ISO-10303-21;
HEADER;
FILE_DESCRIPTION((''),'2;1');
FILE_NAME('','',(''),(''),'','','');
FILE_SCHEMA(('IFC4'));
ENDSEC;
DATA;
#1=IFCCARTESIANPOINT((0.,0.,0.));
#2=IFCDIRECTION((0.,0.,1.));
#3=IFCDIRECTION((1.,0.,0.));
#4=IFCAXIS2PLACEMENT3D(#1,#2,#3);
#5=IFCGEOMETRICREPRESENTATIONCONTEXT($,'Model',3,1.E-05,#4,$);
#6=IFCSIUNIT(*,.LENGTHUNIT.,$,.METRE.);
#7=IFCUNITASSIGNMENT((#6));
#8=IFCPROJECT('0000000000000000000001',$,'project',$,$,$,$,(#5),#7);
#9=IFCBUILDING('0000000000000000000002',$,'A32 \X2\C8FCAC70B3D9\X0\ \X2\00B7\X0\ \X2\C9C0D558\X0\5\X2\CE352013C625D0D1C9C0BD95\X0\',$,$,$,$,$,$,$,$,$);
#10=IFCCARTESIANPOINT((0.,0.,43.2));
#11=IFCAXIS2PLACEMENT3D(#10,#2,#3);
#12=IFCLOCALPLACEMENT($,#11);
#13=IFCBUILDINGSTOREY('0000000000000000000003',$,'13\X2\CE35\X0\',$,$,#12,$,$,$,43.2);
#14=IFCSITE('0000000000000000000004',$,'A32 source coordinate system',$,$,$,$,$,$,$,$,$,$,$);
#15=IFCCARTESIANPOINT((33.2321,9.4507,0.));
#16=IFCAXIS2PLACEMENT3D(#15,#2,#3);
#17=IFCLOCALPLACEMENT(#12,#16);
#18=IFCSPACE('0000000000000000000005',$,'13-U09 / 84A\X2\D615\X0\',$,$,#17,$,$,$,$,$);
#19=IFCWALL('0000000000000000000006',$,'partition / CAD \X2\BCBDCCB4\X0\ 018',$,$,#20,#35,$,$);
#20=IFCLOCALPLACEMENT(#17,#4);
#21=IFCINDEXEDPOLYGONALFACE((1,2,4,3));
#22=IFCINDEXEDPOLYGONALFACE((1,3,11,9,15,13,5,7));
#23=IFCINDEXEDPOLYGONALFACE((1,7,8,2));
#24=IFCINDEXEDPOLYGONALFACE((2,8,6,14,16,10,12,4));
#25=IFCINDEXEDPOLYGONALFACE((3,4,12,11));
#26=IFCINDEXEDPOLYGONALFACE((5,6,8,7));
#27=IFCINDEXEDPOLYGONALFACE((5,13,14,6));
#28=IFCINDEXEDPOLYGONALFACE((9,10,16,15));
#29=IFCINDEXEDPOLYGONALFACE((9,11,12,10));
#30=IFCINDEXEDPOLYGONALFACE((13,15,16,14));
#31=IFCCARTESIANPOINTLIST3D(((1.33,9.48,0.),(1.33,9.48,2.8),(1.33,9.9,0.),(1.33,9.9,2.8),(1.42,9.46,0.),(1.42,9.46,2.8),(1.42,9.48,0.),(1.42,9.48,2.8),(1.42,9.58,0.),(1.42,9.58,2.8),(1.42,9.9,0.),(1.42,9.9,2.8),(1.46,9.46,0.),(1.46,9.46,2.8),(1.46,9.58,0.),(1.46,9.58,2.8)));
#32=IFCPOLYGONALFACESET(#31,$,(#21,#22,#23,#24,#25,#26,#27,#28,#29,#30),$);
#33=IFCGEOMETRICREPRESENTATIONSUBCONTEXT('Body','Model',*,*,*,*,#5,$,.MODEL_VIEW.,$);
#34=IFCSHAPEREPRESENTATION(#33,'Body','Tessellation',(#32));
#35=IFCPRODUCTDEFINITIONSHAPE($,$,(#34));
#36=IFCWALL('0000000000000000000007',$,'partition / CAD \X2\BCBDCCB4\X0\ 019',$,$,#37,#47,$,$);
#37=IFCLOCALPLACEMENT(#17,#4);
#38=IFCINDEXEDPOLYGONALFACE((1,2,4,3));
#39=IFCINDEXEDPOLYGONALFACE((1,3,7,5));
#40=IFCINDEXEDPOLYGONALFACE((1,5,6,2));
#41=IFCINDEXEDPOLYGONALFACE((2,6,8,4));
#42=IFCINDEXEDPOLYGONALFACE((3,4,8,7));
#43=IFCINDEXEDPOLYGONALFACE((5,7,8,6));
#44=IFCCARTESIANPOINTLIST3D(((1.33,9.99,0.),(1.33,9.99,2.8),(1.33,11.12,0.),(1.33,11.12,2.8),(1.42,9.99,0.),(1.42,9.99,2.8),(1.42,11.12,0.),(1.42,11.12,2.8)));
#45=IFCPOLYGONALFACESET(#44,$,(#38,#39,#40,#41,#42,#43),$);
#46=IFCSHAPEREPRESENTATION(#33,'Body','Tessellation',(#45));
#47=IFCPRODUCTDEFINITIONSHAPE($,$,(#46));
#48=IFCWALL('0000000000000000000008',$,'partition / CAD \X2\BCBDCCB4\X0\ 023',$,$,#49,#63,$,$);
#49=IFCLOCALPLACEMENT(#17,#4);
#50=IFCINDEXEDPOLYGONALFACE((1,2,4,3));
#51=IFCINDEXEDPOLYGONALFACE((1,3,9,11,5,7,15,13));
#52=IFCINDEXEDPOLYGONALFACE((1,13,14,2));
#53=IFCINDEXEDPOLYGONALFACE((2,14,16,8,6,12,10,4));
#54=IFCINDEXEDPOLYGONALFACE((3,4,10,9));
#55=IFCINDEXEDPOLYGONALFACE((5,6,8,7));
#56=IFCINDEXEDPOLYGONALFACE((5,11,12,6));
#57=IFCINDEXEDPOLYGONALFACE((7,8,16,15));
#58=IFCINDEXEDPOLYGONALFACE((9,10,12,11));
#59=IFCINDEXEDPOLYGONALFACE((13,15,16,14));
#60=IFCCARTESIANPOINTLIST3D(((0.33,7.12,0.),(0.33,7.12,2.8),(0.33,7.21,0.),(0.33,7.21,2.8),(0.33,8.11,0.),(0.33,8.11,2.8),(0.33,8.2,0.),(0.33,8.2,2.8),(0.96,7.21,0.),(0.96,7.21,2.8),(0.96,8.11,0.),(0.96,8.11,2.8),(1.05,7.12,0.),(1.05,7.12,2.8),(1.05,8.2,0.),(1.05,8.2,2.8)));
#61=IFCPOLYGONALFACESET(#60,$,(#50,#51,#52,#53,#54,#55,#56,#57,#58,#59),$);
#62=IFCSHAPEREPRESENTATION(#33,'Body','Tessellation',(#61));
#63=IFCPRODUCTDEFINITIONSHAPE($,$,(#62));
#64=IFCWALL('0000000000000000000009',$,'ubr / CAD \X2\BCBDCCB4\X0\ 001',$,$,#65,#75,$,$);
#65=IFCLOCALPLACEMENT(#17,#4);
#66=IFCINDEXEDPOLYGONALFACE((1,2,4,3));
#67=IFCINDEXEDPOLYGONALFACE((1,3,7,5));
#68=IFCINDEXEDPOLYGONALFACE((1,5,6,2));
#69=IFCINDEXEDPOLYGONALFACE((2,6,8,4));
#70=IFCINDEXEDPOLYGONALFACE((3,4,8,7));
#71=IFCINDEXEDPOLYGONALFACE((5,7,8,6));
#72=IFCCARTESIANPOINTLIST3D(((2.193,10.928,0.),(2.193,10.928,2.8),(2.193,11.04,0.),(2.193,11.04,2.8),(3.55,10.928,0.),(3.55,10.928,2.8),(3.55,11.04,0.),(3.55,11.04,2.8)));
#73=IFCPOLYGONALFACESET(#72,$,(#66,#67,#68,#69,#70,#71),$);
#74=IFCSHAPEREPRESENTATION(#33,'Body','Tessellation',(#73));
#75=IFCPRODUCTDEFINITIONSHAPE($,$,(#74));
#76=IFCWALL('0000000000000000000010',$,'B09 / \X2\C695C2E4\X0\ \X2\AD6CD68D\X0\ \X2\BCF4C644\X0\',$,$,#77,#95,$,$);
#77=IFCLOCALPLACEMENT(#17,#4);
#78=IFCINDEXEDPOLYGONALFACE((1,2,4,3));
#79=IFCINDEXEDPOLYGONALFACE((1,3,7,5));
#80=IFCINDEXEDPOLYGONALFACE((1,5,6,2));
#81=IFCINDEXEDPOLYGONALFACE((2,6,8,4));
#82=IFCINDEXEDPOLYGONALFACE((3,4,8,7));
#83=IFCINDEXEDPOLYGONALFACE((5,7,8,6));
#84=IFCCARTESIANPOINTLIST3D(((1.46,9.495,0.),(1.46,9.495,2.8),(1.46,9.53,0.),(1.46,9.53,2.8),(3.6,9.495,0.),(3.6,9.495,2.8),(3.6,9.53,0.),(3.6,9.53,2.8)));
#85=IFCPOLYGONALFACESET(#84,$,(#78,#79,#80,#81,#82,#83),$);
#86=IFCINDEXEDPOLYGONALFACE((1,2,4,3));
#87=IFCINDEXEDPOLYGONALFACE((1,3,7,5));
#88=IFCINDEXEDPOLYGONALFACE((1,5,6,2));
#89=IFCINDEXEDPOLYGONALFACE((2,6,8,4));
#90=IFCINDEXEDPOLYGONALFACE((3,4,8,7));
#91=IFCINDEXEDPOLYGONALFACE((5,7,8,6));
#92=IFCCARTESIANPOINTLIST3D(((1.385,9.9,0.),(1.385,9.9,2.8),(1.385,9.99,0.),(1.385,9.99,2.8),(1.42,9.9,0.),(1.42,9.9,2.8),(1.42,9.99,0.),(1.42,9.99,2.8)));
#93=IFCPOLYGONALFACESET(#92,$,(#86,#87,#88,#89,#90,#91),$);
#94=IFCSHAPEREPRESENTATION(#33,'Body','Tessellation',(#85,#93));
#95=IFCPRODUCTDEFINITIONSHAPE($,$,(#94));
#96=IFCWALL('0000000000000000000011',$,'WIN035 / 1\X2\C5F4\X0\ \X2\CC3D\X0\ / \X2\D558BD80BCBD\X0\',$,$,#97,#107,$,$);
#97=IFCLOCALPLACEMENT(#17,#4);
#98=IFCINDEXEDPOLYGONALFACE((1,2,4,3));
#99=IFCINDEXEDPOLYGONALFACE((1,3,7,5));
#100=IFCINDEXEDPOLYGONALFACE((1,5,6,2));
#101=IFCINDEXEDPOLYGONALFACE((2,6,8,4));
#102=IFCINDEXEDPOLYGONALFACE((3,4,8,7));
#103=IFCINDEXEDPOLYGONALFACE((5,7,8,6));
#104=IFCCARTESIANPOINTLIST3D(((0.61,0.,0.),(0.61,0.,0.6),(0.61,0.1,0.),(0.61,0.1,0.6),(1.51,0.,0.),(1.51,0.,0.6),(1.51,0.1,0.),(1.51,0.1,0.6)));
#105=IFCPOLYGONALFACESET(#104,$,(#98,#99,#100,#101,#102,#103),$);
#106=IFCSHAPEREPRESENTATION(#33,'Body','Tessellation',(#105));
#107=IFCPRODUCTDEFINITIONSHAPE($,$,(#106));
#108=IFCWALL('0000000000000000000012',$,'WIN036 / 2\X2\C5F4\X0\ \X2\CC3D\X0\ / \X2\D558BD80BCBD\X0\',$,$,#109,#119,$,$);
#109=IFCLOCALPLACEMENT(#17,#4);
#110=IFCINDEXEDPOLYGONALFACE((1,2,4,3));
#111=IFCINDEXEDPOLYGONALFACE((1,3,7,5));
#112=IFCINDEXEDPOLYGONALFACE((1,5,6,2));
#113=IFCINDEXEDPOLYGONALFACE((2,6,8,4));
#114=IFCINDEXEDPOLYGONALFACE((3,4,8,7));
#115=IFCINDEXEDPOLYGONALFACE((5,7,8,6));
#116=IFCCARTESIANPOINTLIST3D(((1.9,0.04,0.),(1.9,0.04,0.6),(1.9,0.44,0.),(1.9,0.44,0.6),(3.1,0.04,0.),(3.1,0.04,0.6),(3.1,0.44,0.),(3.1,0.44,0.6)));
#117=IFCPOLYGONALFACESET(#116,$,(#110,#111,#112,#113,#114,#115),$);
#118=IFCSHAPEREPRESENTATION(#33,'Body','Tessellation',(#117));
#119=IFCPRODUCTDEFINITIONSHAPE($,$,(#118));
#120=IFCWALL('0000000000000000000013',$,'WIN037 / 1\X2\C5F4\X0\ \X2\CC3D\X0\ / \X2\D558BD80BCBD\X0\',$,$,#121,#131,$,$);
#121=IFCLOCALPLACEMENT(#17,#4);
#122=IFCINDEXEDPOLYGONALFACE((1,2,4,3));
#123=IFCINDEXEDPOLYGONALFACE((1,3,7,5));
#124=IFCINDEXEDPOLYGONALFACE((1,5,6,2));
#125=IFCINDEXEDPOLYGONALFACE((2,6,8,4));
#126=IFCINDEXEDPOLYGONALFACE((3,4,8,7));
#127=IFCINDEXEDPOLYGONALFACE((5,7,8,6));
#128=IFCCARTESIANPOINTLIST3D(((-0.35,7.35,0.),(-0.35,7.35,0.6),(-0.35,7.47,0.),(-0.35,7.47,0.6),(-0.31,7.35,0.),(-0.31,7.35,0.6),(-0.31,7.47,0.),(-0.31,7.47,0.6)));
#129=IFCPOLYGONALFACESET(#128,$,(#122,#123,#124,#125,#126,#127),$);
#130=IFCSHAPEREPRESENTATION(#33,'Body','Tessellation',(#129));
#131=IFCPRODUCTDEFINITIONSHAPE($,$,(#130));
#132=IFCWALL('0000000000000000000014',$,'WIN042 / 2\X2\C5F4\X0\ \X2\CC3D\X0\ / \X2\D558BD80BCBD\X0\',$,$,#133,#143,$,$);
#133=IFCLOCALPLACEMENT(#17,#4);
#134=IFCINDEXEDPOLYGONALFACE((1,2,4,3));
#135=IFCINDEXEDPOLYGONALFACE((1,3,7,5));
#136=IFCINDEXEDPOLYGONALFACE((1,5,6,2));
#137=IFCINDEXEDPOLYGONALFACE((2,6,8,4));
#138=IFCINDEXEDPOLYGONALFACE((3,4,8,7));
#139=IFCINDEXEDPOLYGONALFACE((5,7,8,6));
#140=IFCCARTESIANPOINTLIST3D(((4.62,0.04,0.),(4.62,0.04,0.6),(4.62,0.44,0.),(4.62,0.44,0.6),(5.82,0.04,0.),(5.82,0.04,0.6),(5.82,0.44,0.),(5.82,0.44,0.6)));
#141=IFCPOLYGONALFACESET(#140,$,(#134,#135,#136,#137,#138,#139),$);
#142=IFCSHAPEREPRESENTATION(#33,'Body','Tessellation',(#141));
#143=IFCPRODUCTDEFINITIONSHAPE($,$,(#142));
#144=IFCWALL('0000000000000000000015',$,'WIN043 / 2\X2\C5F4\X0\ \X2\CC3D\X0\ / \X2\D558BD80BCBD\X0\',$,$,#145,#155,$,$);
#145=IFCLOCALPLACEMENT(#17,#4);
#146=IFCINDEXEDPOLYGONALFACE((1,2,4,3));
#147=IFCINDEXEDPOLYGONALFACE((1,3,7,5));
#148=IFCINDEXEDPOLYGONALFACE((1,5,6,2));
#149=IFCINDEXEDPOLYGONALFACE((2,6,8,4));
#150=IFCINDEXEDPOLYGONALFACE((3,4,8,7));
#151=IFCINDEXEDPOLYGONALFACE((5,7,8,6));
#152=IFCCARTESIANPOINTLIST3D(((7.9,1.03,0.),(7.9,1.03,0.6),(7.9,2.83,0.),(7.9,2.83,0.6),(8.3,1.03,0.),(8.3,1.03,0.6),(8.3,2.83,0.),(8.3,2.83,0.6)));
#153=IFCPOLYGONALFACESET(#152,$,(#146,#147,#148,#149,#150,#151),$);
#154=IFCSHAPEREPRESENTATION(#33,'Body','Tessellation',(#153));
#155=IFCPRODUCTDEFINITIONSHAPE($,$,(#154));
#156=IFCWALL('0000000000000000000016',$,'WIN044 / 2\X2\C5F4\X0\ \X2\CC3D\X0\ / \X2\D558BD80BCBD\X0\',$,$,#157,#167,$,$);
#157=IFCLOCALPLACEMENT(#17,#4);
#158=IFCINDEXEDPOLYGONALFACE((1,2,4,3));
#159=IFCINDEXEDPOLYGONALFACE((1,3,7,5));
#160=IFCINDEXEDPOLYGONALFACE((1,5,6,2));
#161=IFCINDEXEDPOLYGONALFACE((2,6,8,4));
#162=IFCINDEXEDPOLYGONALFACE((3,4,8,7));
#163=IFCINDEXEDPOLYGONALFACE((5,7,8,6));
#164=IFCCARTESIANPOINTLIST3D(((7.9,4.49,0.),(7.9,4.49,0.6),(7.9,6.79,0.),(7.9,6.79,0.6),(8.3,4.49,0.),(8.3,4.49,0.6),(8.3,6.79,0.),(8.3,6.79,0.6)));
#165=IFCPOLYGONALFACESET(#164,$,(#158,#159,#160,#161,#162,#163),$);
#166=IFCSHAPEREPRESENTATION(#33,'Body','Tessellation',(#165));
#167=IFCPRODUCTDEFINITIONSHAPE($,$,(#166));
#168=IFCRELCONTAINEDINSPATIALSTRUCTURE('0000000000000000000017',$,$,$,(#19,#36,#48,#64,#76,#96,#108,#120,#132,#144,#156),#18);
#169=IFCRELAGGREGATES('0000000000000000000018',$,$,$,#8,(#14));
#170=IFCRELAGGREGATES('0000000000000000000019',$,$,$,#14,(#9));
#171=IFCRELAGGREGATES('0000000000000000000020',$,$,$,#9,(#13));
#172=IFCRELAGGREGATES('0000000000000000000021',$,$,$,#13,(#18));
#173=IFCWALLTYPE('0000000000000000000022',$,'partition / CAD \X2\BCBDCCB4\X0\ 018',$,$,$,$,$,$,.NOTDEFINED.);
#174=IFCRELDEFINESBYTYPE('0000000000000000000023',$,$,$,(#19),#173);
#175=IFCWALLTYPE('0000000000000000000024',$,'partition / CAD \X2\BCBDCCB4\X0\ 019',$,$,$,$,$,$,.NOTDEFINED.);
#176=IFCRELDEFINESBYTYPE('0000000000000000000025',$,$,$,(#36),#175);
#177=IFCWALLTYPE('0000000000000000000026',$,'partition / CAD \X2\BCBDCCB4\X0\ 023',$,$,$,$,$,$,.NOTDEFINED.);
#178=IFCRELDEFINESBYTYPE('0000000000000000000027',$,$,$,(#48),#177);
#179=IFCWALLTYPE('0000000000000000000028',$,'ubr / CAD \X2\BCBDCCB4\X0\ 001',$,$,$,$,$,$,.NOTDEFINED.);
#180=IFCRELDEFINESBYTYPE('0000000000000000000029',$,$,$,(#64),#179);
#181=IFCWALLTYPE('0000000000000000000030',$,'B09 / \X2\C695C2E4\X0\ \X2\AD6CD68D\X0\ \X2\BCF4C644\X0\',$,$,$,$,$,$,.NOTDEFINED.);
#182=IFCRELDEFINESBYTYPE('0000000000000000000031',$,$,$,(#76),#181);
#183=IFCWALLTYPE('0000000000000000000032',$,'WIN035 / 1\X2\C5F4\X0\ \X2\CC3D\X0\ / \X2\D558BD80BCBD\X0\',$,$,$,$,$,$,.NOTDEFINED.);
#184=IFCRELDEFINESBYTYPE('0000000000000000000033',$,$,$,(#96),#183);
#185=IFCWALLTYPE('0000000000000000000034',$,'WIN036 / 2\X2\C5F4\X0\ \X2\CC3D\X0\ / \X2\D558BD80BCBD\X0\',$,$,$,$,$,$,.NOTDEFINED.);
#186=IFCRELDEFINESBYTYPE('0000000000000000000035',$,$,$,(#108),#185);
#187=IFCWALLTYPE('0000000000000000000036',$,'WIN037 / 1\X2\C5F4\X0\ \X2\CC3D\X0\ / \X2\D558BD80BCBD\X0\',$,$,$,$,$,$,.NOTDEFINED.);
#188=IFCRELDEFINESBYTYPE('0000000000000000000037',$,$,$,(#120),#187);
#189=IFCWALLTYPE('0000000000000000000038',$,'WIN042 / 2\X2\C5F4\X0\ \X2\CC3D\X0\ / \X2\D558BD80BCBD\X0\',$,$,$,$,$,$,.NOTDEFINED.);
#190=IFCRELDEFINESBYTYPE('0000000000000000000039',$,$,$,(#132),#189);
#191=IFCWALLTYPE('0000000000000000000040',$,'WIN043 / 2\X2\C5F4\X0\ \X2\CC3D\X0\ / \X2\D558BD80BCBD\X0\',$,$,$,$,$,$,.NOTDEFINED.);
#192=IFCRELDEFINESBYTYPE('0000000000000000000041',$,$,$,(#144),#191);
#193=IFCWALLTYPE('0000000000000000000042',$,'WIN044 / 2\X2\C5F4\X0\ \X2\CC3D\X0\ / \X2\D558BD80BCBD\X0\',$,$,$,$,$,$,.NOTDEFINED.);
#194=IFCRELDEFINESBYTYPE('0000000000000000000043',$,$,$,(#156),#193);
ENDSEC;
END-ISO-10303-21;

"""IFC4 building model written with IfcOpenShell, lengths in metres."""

from ifc_helpers import new_model, si_unit, frame, origin, origin_with_axes, place, context, subcontext, project, spatial, polyline, outline, extrude, source, transform, mapped, type_object, type_shapes, element, save


model = new_model("IFC4")

# Units and contexts
model_context = context("Model", 3, precision=1e-05, world=origin_with_axes())
body_context = subcontext(model_context, "Body", "Model", "MODEL_VIEW")
ifc_project = project(units=[si_unit("LENGTHUNIT", "METRE")], contexts=[model_context])

# Site, building, storey, space
site = spatial("IfcSite", under=ifc_project, Name="A32 source coordinate system")
building = spatial("IfcBuilding", under=site, Name="A32 주거동 · 지하5층–옥탑지붕")
storey_placement = place(None, frame((0.0, 0.0, 43.2), z_axis=(0.0, 0.0, 1.0), x_axis=(1.0, 0.0, 0.0)))
storey = spatial("IfcBuildingStorey", under=building, at=storey_placement, Name="13층", Elevation=43.2)
space_1_placement = place(storey_placement, frame((33.2321, 9.4507, 0.0), z_axis=(0.0, 0.0, 1.0), x_axis=(1.0, 0.0, 0.0)))
space_1 = spatial("IfcSpace", under=storey, at=space_1_placement, Name="13-U09 / 84A형")

# Walls
wall_type_1 = type_object("IfcWallType", Name="partition / CAD 벽체 018", PredefinedType="NOTDEFINED")
shared_shape_1 = source(origin(), body_context, "Body", "SweptSolid", [
    extrude(outline(polyline([(1.42, 9.58), (1.46, 9.58), (1.46, 9.46), (1.42, 9.46), (1.42, 9.48), (1.33, 9.48), (1.33, 9.9), (1.42, 9.9), (1.42, 9.58)])), origin(), (0.0, 0.0, 1.0), 2.8),
])
type_shapes(wall_type_1, [shared_shape_1])
wall_1_placement = place(space_1_placement, origin_with_axes())
element("IfcWall", 1, at=wall_1_placement, inside=space_1, type_object=wall_type_1, Name="partition / CAD 벽체 018", context=body_context, shape_type="MappedRepresentation", body=[
    mapped(shared_shape_1, transform((0.0, 0.0, 0.0), scale=1.0)),
])
wall_type_2 = type_object("IfcWallType", Name="partition / CAD 벽체 019", PredefinedType="NOTDEFINED")
shared_shape_2 = source(origin(), body_context, "Body", "SweptSolid", [
    extrude(outline(polyline([(1.33, 11.12), (1.42, 11.12), (1.42, 9.99), (1.33, 9.99), (1.33, 11.12)])), origin(), (0.0, 0.0, 1.0), 2.8),
])
type_shapes(wall_type_2, [shared_shape_2])
wall_2_placement = place(space_1_placement, origin_with_axes())
element("IfcWall", 2, at=wall_2_placement, inside=space_1, type_object=wall_type_2, Name="partition / CAD 벽체 019", context=body_context, shape_type="MappedRepresentation", body=[
    mapped(shared_shape_2, transform((0.0, 0.0, 0.0), scale=1.0)),
])
wall_type_3 = type_object("IfcWallType", Name="partition / CAD 벽체 023", PredefinedType="NOTDEFINED")
shared_shape_3 = source(origin(), body_context, "Body", "SweptSolid", [
    extrude(outline(polyline([(0.96, 8.11), (0.33, 8.11), (0.33, 8.2), (1.05, 8.2), (1.05, 7.12), (0.33, 7.12), (0.33, 7.21), (0.96, 7.21), (0.96, 8.11)])), origin(), (0.0, 0.0, 1.0), 2.8),
])
type_shapes(wall_type_3, [shared_shape_3])
wall_3_placement = place(space_1_placement, origin_with_axes())
element("IfcWall", 3, at=wall_3_placement, inside=space_1, type_object=wall_type_3, Name="partition / CAD 벽체 023", context=body_context, shape_type="MappedRepresentation", body=[
    mapped(shared_shape_3, transform((0.0, 0.0, 0.0), scale=1.0)),
])
wall_type_4 = type_object("IfcWallType", Name="ubr / CAD 벽체 001", PredefinedType="NOTDEFINED")
shared_shape_4 = source(origin(), body_context, "Body", "SweptSolid", [
    extrude(outline(polyline([(3.55, 11.04), (3.55, 10.928), (2.193, 10.928), (2.193, 11.04), (3.55, 11.04)])), origin(), (0.0, 0.0, 1.0), 2.8),
])
type_shapes(wall_type_4, [shared_shape_4])
wall_4_placement = place(space_1_placement, origin_with_axes())
element("IfcWall", 4, at=wall_4_placement, inside=space_1, type_object=wall_type_4, Name="ubr / CAD 벽체 001", context=body_context, shape_type="MappedRepresentation", body=[
    mapped(shared_shape_4, transform((0.0, 0.0, 0.0), scale=1.0)),
])
wall_type_5 = type_object("IfcWallType", Name="B09 / 욕실 구획 보완", PredefinedType="NOTDEFINED")
shared_shape_5 = source(origin(), body_context, "Body", "SweptSolid", [
    extrude(outline(polyline([(3.6, 9.53), (3.6, 9.495), (1.46, 9.495), (1.46, 9.53), (3.6, 9.53)])), origin(), (0.0, 0.0, 1.0), 2.8),
    extrude(outline(polyline([(1.42, 9.9), (1.385, 9.9), (1.385, 9.99), (1.42, 9.99), (1.42, 9.9)])), origin(), (0.0, 0.0, 1.0), 2.8),
])
type_shapes(wall_type_5, [shared_shape_5])
wall_5_placement = place(space_1_placement, origin_with_axes())
element("IfcWall", 5, at=wall_5_placement, inside=space_1, type_object=wall_type_5, Name="B09 / 욕실 구획 보완", context=body_context, shape_type="MappedRepresentation", body=[
    mapped(shared_shape_5, transform((0.0, 0.0, 0.0), scale=1.0)),
])
wall_type_6 = type_object("IfcWallType", Name="WIN035 / 1열 창 / 하부벽", PredefinedType="NOTDEFINED")
shared_shape_6 = source(origin(), body_context, "Body", "SweptSolid", [
    extrude(outline(polyline([(0.61, 0.1), (1.51, 0.1), (1.51, 0.0), (0.61, 0.0), (0.61, 0.1)])), origin(), (0.0, 0.0, 1.0), 0.6),
])
type_shapes(wall_type_6, [shared_shape_6])
wall_6_placement = place(space_1_placement, origin_with_axes())
element("IfcWall", 6, at=wall_6_placement, inside=space_1, type_object=wall_type_6, Name="WIN035 / 1열 창 / 하부벽", context=body_context, shape_type="MappedRepresentation", body=[
    mapped(shared_shape_6, transform((0.0, 0.0, 0.0), scale=1.0)),
])
wall_type_7 = type_object("IfcWallType", Name="WIN036 / 2열 창 / 하부벽", PredefinedType="NOTDEFINED")
shared_shape_7 = source(origin(), body_context, "Body", "SweptSolid", [
    extrude(outline(polyline([(1.9, 0.44), (3.1, 0.44), (3.1, 0.04), (1.9, 0.04), (1.9, 0.44)])), origin(), (0.0, 0.0, 1.0), 0.6),
])
type_shapes(wall_type_7, [shared_shape_7])
wall_7_placement = place(space_1_placement, origin_with_axes())
element("IfcWall", 7, at=wall_7_placement, inside=space_1, type_object=wall_type_7, Name="WIN036 / 2열 창 / 하부벽", context=body_context, shape_type="MappedRepresentation", body=[
    mapped(shared_shape_7, transform((0.0, 0.0, 0.0), scale=1.0)),
])
wall_type_8 = type_object("IfcWallType", Name="WIN037 / 1열 창 / 하부벽", PredefinedType="NOTDEFINED")
shared_shape_8 = source(origin(), body_context, "Body", "SweptSolid", [
    extrude(outline(polyline([(-0.31, 7.47), (-0.31, 7.35), (-0.35, 7.35), (-0.35, 7.47), (-0.31, 7.47)])), origin(), (0.0, 0.0, 1.0), 0.6),
])
type_shapes(wall_type_8, [shared_shape_8])
wall_8_placement = place(space_1_placement, origin_with_axes())
element("IfcWall", 8, at=wall_8_placement, inside=space_1, type_object=wall_type_8, Name="WIN037 / 1열 창 / 하부벽", context=body_context, shape_type="MappedRepresentation", body=[
    mapped(shared_shape_8, transform((0.0, 0.0, 0.0), scale=1.0)),
])
wall_type_9 = type_object("IfcWallType", Name="WIN042 / 2열 창 / 하부벽", PredefinedType="NOTDEFINED")
shared_shape_9 = source(origin(), body_context, "Body", "SweptSolid", [
    extrude(outline(polyline([(4.62, 0.44), (5.82, 0.44), (5.82, 0.04), (4.62, 0.04), (4.62, 0.44)])), origin(), (0.0, 0.0, 1.0), 0.6),
])
type_shapes(wall_type_9, [shared_shape_9])
wall_9_placement = place(space_1_placement, origin_with_axes())
element("IfcWall", 9, at=wall_9_placement, inside=space_1, type_object=wall_type_9, Name="WIN042 / 2열 창 / 하부벽", context=body_context, shape_type="MappedRepresentation", body=[
    mapped(shared_shape_9, transform((0.0, 0.0, 0.0), scale=1.0)),
])
wall_type_10 = type_object("IfcWallType", Name="WIN043 / 2열 창 / 하부벽", PredefinedType="NOTDEFINED")
shared_shape_10 = source(origin(), body_context, "Body", "SweptSolid", [
    extrude(outline(polyline([(7.9, 2.83), (8.3, 2.83), (8.3, 1.03), (7.9, 1.03), (7.9, 2.83)])), origin(), (0.0, 0.0, 1.0), 0.6),
])
type_shapes(wall_type_10, [shared_shape_10])
wall_10_placement = place(space_1_placement, origin_with_axes())
element("IfcWall", 10, at=wall_10_placement, inside=space_1, type_object=wall_type_10, Name="WIN043 / 2열 창 / 하부벽", context=body_context, shape_type="MappedRepresentation", body=[
    mapped(shared_shape_10, transform((0.0, 0.0, 0.0), scale=1.0)),
])
wall_type_11 = type_object("IfcWallType", Name="WIN044 / 2열 창 / 하부벽", PredefinedType="NOTDEFINED")
shared_shape_11 = source(origin(), body_context, "Body", "SweptSolid", [
    extrude(outline(polyline([(7.9, 6.79), (8.3, 6.79), (8.3, 4.49), (7.9, 4.49), (7.9, 6.79)])), origin(), (0.0, 0.0, 1.0), 0.6),
])
type_shapes(wall_type_11, [shared_shape_11])
wall_11_placement = place(space_1_placement, origin_with_axes())
element("IfcWall", 11, at=wall_11_placement, inside=space_1, type_object=wall_type_11, Name="WIN044 / 2열 창 / 하부벽", context=body_context, shape_type="MappedRepresentation", body=[
    mapped(shared_shape_11, transform((0.0, 0.0, 0.0), scale=1.0)),
])

save(model, "model.ifc")
